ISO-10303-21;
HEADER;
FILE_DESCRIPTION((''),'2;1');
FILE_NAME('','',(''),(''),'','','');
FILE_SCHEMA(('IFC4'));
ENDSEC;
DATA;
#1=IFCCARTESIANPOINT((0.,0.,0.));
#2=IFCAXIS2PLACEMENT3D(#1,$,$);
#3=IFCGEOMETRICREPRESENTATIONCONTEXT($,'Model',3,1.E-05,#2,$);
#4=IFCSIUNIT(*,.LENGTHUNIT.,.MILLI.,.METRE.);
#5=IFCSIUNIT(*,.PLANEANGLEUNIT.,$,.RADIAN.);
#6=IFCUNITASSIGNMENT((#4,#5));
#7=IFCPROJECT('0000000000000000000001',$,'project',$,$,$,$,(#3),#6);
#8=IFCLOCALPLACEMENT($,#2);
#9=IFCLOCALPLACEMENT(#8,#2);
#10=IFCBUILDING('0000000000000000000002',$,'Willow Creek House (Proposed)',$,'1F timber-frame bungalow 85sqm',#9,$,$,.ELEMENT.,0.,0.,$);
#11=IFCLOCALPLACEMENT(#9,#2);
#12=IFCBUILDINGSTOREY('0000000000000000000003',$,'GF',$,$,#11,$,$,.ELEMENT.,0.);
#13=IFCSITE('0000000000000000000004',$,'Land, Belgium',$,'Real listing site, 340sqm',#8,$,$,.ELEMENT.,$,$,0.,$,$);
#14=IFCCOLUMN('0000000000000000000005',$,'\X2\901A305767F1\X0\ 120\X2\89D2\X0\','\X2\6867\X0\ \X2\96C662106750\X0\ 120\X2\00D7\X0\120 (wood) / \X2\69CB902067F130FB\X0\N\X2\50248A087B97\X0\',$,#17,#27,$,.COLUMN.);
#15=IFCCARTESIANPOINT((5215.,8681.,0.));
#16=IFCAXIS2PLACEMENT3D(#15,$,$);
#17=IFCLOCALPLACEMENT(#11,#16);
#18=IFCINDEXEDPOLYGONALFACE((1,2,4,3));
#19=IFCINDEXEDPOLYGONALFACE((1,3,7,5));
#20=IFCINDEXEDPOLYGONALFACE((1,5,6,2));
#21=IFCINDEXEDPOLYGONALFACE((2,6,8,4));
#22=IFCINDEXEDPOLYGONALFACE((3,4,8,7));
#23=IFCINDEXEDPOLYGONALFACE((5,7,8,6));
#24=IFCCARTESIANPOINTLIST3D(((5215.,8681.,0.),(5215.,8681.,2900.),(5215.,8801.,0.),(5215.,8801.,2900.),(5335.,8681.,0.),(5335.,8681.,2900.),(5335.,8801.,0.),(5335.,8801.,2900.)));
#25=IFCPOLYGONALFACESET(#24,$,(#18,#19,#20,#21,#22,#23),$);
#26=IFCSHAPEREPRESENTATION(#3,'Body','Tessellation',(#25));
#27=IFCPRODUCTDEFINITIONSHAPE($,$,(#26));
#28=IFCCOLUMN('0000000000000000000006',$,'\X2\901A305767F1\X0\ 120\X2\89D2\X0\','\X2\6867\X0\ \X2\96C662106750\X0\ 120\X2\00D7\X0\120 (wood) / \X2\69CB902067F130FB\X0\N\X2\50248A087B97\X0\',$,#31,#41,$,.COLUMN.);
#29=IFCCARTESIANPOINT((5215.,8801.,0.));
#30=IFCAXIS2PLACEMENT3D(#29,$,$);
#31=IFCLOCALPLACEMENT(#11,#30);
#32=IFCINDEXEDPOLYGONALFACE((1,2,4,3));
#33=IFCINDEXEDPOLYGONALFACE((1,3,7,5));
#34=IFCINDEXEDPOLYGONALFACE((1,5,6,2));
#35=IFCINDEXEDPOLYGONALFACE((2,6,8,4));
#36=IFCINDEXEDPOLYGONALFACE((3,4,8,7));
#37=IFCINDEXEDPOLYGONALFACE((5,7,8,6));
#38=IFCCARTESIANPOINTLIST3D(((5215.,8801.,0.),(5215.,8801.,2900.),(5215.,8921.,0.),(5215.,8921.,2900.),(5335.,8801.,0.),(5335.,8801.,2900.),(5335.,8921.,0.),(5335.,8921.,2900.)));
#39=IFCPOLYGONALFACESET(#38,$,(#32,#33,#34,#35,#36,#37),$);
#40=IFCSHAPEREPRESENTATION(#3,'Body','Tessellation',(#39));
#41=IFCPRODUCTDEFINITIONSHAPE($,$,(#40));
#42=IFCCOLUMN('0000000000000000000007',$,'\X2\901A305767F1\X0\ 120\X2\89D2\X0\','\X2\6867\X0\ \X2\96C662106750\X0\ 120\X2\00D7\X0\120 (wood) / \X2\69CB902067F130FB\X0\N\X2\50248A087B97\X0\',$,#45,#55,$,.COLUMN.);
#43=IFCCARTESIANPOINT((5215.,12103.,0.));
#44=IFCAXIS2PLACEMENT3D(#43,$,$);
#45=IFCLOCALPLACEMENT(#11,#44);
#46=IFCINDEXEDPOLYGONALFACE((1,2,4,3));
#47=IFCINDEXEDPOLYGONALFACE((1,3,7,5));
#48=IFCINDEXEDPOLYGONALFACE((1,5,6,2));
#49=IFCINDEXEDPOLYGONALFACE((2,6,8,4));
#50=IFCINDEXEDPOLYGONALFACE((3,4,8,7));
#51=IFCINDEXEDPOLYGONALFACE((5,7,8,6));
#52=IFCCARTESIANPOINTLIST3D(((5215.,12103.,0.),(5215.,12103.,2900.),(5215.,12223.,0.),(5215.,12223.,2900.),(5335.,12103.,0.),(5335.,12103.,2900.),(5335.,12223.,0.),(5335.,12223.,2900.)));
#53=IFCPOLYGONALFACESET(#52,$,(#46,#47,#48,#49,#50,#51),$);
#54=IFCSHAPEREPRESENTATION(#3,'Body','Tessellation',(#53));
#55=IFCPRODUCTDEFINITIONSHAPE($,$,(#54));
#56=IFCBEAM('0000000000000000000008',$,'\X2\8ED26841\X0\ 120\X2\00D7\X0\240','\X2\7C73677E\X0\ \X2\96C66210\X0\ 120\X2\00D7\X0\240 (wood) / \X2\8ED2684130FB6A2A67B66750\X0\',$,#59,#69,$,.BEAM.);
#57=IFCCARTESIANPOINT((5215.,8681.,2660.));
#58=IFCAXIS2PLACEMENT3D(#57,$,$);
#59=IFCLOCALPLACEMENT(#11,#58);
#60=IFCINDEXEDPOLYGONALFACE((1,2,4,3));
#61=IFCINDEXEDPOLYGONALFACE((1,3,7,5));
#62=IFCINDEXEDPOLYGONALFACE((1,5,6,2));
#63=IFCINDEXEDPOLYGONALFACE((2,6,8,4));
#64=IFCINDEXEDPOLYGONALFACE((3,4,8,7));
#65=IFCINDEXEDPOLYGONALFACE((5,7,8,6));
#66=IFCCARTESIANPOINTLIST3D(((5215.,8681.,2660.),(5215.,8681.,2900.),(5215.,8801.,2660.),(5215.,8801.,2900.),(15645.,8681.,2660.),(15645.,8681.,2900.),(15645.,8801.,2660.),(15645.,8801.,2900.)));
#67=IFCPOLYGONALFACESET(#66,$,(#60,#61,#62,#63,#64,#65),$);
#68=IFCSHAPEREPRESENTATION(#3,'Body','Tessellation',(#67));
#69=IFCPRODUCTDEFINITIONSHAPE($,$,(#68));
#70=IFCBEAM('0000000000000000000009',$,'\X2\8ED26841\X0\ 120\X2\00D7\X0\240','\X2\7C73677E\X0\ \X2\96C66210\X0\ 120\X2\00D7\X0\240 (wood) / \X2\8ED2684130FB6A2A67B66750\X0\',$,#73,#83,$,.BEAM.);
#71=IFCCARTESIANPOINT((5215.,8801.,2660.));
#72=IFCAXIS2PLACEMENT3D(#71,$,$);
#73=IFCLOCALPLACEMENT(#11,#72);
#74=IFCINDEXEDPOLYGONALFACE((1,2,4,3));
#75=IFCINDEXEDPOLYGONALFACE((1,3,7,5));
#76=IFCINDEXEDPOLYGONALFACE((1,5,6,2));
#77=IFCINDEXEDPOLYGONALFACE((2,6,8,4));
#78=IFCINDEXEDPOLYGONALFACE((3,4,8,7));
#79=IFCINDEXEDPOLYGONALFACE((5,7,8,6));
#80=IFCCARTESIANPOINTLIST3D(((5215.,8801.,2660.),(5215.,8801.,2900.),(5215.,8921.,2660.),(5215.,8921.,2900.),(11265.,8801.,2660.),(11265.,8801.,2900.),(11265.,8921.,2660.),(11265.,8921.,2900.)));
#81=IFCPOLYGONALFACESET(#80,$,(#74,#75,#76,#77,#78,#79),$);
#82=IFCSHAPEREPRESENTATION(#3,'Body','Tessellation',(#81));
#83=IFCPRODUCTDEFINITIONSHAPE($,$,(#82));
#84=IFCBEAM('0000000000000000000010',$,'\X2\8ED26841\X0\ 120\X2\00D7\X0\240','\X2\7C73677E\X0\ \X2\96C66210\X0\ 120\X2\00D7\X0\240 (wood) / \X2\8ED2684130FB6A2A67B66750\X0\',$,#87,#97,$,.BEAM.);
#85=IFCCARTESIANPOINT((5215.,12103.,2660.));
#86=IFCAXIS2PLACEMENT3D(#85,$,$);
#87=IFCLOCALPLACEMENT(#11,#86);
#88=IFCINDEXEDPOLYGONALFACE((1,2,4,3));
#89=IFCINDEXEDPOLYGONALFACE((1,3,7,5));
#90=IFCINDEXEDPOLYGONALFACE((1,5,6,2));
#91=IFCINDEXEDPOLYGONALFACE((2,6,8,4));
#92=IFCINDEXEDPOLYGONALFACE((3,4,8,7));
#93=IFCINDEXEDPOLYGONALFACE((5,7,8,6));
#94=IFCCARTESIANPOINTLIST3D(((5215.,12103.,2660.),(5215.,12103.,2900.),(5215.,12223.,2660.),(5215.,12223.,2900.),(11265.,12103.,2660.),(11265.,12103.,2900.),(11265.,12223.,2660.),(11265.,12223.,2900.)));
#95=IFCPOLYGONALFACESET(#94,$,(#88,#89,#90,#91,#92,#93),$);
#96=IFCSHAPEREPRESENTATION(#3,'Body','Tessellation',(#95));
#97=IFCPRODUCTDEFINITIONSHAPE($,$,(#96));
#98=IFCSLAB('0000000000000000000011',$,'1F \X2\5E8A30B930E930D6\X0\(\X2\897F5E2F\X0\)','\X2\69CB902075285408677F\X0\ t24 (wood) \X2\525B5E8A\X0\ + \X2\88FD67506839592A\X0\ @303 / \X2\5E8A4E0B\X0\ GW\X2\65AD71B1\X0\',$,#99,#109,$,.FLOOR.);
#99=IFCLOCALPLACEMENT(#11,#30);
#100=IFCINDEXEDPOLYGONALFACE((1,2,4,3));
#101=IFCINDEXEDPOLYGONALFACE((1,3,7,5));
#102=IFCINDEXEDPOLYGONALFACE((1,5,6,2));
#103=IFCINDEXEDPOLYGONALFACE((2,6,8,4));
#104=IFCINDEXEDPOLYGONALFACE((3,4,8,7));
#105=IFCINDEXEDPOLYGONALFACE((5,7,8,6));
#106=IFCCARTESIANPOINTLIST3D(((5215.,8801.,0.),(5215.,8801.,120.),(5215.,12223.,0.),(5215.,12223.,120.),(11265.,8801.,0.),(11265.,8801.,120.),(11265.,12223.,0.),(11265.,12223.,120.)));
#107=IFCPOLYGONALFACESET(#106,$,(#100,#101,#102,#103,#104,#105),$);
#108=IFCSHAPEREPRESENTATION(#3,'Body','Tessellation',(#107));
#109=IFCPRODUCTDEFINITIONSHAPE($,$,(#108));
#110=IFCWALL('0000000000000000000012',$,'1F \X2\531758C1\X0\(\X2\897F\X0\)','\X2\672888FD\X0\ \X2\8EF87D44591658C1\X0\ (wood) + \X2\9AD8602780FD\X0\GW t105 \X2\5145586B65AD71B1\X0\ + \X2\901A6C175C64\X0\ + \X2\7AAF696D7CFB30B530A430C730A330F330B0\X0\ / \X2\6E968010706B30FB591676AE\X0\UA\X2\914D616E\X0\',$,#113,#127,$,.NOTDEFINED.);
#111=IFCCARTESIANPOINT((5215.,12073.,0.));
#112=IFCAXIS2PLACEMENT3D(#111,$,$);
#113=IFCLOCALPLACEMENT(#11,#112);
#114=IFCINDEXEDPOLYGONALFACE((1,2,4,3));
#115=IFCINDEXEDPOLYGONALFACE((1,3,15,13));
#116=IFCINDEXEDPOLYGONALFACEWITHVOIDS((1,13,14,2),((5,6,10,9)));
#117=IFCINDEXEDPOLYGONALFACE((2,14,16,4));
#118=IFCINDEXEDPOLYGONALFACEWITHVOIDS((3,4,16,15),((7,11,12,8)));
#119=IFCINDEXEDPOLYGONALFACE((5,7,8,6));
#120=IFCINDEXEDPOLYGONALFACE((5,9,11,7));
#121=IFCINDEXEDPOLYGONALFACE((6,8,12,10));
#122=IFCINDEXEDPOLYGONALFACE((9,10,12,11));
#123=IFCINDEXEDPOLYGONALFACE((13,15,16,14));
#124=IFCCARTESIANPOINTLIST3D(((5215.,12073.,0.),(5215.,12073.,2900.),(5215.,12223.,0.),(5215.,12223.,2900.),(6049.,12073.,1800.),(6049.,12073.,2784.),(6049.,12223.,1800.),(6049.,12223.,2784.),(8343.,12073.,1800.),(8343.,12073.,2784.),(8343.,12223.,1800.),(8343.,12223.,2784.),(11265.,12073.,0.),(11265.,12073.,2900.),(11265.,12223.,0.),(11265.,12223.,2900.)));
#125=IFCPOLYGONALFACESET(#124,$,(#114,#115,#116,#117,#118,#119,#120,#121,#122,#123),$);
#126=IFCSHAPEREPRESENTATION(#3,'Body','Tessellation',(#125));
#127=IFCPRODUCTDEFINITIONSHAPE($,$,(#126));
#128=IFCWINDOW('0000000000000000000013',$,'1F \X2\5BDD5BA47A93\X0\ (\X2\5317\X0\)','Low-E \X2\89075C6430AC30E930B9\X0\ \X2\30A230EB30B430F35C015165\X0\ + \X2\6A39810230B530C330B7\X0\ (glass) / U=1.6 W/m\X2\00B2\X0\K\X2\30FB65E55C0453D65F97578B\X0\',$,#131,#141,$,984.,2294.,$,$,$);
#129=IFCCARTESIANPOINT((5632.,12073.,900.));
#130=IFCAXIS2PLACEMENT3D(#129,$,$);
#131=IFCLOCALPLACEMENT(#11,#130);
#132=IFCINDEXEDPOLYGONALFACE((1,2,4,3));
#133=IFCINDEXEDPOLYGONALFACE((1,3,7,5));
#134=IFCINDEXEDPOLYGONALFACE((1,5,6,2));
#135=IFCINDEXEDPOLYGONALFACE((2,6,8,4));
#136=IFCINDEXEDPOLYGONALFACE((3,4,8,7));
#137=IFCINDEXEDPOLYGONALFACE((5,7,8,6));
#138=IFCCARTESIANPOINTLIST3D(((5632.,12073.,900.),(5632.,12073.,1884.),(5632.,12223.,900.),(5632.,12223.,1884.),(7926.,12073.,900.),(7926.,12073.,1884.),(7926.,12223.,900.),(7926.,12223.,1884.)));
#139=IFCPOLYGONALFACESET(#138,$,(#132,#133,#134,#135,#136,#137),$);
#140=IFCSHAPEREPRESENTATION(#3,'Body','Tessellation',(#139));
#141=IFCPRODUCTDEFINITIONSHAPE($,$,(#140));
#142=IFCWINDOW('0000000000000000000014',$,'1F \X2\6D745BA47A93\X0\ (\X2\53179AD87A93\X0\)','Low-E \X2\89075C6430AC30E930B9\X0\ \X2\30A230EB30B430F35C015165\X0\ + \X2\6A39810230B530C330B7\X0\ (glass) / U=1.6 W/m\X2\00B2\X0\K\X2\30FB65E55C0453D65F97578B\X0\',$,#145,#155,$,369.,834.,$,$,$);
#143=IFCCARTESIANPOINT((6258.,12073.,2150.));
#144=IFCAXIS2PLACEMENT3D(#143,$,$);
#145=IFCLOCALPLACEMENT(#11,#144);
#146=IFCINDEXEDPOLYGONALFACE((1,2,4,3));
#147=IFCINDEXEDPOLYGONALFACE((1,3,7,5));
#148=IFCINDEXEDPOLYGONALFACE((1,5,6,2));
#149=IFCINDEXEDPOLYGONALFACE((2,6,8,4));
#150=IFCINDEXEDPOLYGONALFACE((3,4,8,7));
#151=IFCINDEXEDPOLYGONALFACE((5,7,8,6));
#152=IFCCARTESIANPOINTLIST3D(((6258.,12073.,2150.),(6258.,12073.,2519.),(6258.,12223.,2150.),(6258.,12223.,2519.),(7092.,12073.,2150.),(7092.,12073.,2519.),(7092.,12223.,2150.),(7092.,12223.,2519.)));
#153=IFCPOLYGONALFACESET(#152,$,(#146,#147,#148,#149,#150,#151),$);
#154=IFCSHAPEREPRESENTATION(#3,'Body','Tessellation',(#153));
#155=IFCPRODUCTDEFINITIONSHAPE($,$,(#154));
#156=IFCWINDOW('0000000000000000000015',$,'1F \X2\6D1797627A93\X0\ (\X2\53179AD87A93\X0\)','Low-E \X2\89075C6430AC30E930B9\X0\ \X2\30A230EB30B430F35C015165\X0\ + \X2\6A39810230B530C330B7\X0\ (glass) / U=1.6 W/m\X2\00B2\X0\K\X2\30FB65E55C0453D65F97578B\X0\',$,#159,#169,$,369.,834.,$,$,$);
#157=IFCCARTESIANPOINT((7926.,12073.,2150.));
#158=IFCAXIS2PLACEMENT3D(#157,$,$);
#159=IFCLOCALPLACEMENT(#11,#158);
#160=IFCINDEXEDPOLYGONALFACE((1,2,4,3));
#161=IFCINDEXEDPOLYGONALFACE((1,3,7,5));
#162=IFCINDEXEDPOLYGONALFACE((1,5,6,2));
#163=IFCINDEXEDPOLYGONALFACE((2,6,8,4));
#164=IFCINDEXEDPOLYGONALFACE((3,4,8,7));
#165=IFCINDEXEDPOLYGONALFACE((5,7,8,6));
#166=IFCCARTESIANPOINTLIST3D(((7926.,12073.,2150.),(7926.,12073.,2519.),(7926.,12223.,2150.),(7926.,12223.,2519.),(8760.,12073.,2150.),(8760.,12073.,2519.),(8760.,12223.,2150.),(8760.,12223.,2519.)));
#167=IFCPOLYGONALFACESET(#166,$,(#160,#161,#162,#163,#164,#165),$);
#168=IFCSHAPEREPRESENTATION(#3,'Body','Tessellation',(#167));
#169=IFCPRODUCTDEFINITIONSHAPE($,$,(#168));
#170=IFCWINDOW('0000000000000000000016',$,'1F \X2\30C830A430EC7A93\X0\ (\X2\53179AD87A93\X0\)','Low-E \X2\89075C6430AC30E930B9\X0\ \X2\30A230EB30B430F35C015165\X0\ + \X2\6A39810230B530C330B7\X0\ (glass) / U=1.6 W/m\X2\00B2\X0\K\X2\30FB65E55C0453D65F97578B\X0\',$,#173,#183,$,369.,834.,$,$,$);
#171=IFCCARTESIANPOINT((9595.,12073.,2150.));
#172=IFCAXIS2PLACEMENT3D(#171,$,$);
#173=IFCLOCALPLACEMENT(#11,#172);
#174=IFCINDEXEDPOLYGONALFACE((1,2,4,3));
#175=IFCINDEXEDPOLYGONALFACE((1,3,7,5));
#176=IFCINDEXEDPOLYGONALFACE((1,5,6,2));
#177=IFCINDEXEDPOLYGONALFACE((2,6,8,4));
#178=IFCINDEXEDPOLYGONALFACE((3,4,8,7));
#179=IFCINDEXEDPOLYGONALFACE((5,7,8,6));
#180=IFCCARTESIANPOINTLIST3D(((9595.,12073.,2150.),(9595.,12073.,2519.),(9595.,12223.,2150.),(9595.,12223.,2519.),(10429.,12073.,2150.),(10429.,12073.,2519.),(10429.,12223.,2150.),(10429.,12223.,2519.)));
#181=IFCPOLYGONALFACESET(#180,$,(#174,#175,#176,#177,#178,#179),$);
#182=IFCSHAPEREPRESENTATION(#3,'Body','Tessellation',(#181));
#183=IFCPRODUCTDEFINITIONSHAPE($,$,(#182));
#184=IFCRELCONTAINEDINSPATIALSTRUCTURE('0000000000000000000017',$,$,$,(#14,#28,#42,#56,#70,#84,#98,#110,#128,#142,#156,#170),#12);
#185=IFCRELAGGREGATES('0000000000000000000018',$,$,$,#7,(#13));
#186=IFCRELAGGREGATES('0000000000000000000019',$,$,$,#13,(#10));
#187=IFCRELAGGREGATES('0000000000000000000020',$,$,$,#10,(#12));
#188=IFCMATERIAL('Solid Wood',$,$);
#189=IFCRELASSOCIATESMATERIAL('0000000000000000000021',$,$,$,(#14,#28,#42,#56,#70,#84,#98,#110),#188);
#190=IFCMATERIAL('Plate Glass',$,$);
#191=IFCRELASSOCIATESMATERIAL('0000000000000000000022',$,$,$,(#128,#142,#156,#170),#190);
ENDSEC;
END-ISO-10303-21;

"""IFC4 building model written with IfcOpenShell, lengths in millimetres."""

from ifc_helpers import new_model, si_unit, frame, frame_2d, origin, place, context, project, spatial, rectangle, extrude, material, element, fill, save


model = new_model("IFC4")

# Units and contexts
model_context = context("Model", 3, precision=1e-05, world=origin())
ifc_project = project(units=[si_unit("LENGTHUNIT", "METRE", prefix="MILLI"), si_unit("PLANEANGLEUNIT", "RADIAN")], contexts=[model_context])

# Site, building, storey
site_placement = place(None, origin())
site = spatial("IfcSite", under=ifc_project, at=site_placement, Name="Land, Belgium", ObjectType="Real listing site, 340sqm", CompositionType="ELEMENT", RefElevation=0.0)
building_placement = place(site_placement, origin())
building = spatial("IfcBuilding", under=site, at=building_placement, Name="Willow Creek House (Proposed)", ObjectType="1F timber-frame bungalow 85sqm", CompositionType="ELEMENT", ElevationOfRefHeight=0.0, ElevationOfTerrain=0.0)
storey_placement = place(building_placement, origin())
storey = spatial("IfcBuildingStorey", under=building, at=storey_placement, Name="GF", CompositionType="ELEMENT", Elevation=0.0)

# Columns
ifc_material_1 = material(Name="Solid Wood")
column_1_placement = place(storey_placement, frame((5215.0, 8681.0, 0.0)))
element("IfcColumn", 1, at=column_1_placement, inside=storey, material=ifc_material_1, Name="通し柱 120角", Description="桧 集成材 120×120 (wood) / 構造柱・N値計算", PredefinedType="COLUMN", context=model_context, shape_type="SweptSolid", body=[
    extrude(rectangle(XDim=120.0, YDim=120.0, at=frame_2d((60.0, 60.0))), frame((5215.0, 8681.0, 0.0)), (0.0, 0.0, 1.0), 2900.0),
])
column_2_placement = place(storey_placement, frame((5215.0, 8801.0, 0.0)))
element("IfcColumn", 2, at=column_2_placement, inside=storey, material=ifc_material_1, Name="通し柱 120角", Description="桧 集成材 120×120 (wood) / 構造柱・N値計算", PredefinedType="COLUMN", context=model_context, shape_type="SweptSolid", body=[
    extrude(rectangle(XDim=120.0, YDim=120.0, at=frame_2d((60.0, 60.0))), frame((5215.0, 8801.0, 0.0)), (0.0, 0.0, 1.0), 2900.0),
])
column_3_placement = place(storey_placement, frame((5215.0, 12103.0, 0.0)))
element("IfcColumn", 3, at=column_3_placement, inside=storey, material=ifc_material_1, Name="通し柱 120角", Description="桧 集成材 120×120 (wood) / 構造柱・N値計算", PredefinedType="COLUMN", context=model_context, shape_type="SweptSolid", body=[
    extrude(rectangle(XDim=120.0, YDim=120.0, at=frame_2d((60.0, 60.0))), frame((5215.0, 12103.0, 0.0)), (0.0, 0.0, 1.0), 2900.0),
])

# Beams
beam_1_placement = place(storey_placement, frame((5215.0, 8681.0, 2660.0)))
element("IfcBeam", 4, at=beam_1_placement, inside=storey, material=ifc_material_1, Name="軒桁 120×240", Description="米松 集成 120×240 (wood) / 軒桁・横架材", PredefinedType="BEAM", context=model_context, shape_type="SweptSolid", body=[
    extrude(rectangle(XDim=10430.0, YDim=120.0, at=frame_2d((5215.0, 60.0))), frame((5215.0, 8681.0, 2660.0)), (0.0, 0.0, 1.0), 240.0),
])
beam_2_placement = place(storey_placement, frame((5215.0, 8801.0, 2660.0)))
element("IfcBeam", 5, at=beam_2_placement, inside=storey, material=ifc_material_1, Name="軒桁 120×240", Description="米松 集成 120×240 (wood) / 軒桁・横架材", PredefinedType="BEAM", context=model_context, shape_type="SweptSolid", body=[
    extrude(rectangle(XDim=6050.0, YDim=120.0, at=frame_2d((3025.0, 60.0))), frame((5215.0, 8801.0, 2660.0)), (0.0, 0.0, 1.0), 240.0),
])
beam_3_placement = place(storey_placement, frame((5215.0, 12103.0, 2660.0)))
element("IfcBeam", 6, at=beam_3_placement, inside=storey, material=ifc_material_1, Name="軒桁 120×240", Description="米松 集成 120×240 (wood) / 軒桁・横架材", PredefinedType="BEAM", context=model_context, shape_type="SweptSolid", body=[
    extrude(rectangle(XDim=6050.0, YDim=120.0, at=frame_2d((3025.0, 60.0))), frame((5215.0, 12103.0, 2660.0)), (0.0, 0.0, 1.0), 240.0),
])

# Slab
slab_placement = place(storey_placement, frame((5215.0, 8801.0, 0.0)))
element("IfcSlab", 7, at=slab_placement, inside=storey, material=ifc_material_1, Name="1F 床スラブ(西帯)", Description="構造用合板 t24 (wood) 剛床 + 製材根太 @303 / 床下 GW断熱", PredefinedType="FLOOR", context=model_context, shape_type="SweptSolid", body=[
    extrude(rectangle(XDim=6050.0, YDim=3422.0, at=frame_2d((3025.0, 1711.0))), frame((5215.0, 8801.0, 0.0)), (0.0, 0.0, 1.0), 120.0),
])

# Wall, openings, windows
wall_1_placement = place(storey_placement, frame((5215.0, 12073.0, 0.0)))
wall_1 = element("IfcWall", 8, at=wall_1_placement, inside=storey, material=ifc_material_1, Name="1F 北壁(西)", Description="木製 軸組外壁 (wood) + 高性能GW t105 充填断熱 + 通気層 + 窯業系サイディング / 準耐火・外皮UA配慮", PredefinedType="NOTDEFINED", context=model_context, shape_type="SweptSolid", body=[
    extrude(rectangle(XDim=6050.0, YDim=150.0, at=frame_2d((3025.0, 75.0))), frame((5215.0, 12073.0, 0.0)), (0.0, 0.0, 1.0), 2900.0),
])
opening_1_placement = place(storey_placement, frame((5632.0, 12073.0, 900.0)))
opening_1 = element("IfcOpeningElement", 9, at=opening_1_placement, cuts=wall_1, PredefinedType="NOTDEFINED", context=model_context, shape_type="SweptSolid", body=[
    extrude(rectangle(XDim=2294.0, YDim=150.0, at=frame_2d((1147.0, 75.0))), frame((5632.0, 12073.0, 900.0)), (0.0, 0.0, 1.0), 984.0),
])
opening_2_placement = place(storey_placement, frame((6258.0, 12073.0, 2150.0)))
opening_2 = element("IfcOpeningElement", 10, at=opening_2_placement, cuts=wall_1, PredefinedType="NOTDEFINED", context=model_context, shape_type="SweptSolid", body=[
    extrude(rectangle(XDim=834.0, YDim=150.0, at=frame_2d((417.0, 75.0))), frame((6258.0, 12073.0, 2150.0)), (0.0, 0.0, 1.0), 369.0),
])
opening_3_placement = place(storey_placement, frame((7926.0, 12073.0, 2150.0)))
opening_3 = element("IfcOpeningElement", 11, at=opening_3_placement, cuts=wall_1, PredefinedType="NOTDEFINED", context=model_context, shape_type="SweptSolid", body=[
    extrude(rectangle(XDim=834.0, YDim=150.0, at=frame_2d((417.0, 75.0))), frame((7926.0, 12073.0, 2150.0)), (0.0, 0.0, 1.0), 369.0),
])
opening_4_placement = place(storey_placement, frame((9595.0, 12073.0, 2150.0)))
opening_4 = element("IfcOpeningElement", 12, at=opening_4_placement, cuts=wall_1, PredefinedType="NOTDEFINED", context=model_context, shape_type="SweptSolid", body=[
    extrude(rectangle(XDim=834.0, YDim=150.0, at=frame_2d((417.0, 75.0))), frame((9595.0, 12073.0, 2150.0)), (0.0, 0.0, 1.0), 369.0),
])
ifc_material_2 = material(Name="Plate Glass")
window_1_placement = place(storey_placement, frame((5632.0, 12073.0, 900.0)))
window_1 = element("IfcWindow", 13, at=window_1_placement, inside=storey, material=ifc_material_2, Name="1F 寝室窓 (北)", Description="Low-E 複層ガラス アルゴン封入 + 樹脂サッシ (glass) / U=1.6 W/m²K・日射取得型", OverallHeight=984.0, OverallWidth=2294.0, context=model_context, shape_type="SweptSolid", body=[
    extrude(rectangle(XDim=2294.0, YDim=150.0, at=frame_2d((1147.0, 75.0))), frame((5632.0, 12073.0, 900.0)), (0.0, 0.0, 1.0), 984.0),
])
fill(opening_1, window_1)
window_2_placement = place(storey_placement, frame((6258.0, 12073.0, 2150.0)))
window_2 = element("IfcWindow", 14, at=window_2_placement, inside=storey, material=ifc_material_2, Name="1F 浴室窓 (北高窓)", Description="Low-E 複層ガラス アルゴン封入 + 樹脂サッシ (glass) / U=1.6 W/m²K・日射取得型", OverallHeight=369.0, OverallWidth=834.0, context=model_context, shape_type="SweptSolid", body=[
    extrude(rectangle(XDim=834.0, YDim=150.0, at=frame_2d((417.0, 75.0))), frame((6258.0, 12073.0, 2150.0)), (0.0, 0.0, 1.0), 369.0),
])
fill(opening_2, window_2)
window_3_placement = place(storey_placement, frame((7926.0, 12073.0, 2150.0)))
window_3 = element("IfcWindow", 15, at=window_3_placement, inside=storey, material=ifc_material_2, Name="1F 洗面窓 (北高窓)", Description="Low-E 複層ガラス アルゴン封入 + 樹脂サッシ (glass) / U=1.6 W/m²K・日射取得型", OverallHeight=369.0, OverallWidth=834.0, context=model_context, shape_type="SweptSolid", body=[
    extrude(rectangle(XDim=834.0, YDim=150.0, at=frame_2d((417.0, 75.0))), frame((7926.0, 12073.0, 2150.0)), (0.0, 0.0, 1.0), 369.0),
])
fill(opening_3, window_3)
window_4_placement = place(storey_placement, frame((9595.0, 12073.0, 2150.0)))
window_4 = element("IfcWindow", 16, at=window_4_placement, inside=storey, material=ifc_material_2, Name="1F トイレ窓 (北高窓)", Description="Low-E 複層ガラス アルゴン封入 + 樹脂サッシ (glass) / U=1.6 W/m²K・日射取得型", OverallHeight=369.0, OverallWidth=834.0, context=model_context, shape_type="SweptSolid", body=[
    extrude(rectangle(XDim=834.0, YDim=150.0, at=frame_2d((417.0, 75.0))), frame((9595.0, 12073.0, 2150.0)), (0.0, 0.0, 1.0), 369.0),
])
fill(opening_4, window_4)

save(model, "model.ifc")
